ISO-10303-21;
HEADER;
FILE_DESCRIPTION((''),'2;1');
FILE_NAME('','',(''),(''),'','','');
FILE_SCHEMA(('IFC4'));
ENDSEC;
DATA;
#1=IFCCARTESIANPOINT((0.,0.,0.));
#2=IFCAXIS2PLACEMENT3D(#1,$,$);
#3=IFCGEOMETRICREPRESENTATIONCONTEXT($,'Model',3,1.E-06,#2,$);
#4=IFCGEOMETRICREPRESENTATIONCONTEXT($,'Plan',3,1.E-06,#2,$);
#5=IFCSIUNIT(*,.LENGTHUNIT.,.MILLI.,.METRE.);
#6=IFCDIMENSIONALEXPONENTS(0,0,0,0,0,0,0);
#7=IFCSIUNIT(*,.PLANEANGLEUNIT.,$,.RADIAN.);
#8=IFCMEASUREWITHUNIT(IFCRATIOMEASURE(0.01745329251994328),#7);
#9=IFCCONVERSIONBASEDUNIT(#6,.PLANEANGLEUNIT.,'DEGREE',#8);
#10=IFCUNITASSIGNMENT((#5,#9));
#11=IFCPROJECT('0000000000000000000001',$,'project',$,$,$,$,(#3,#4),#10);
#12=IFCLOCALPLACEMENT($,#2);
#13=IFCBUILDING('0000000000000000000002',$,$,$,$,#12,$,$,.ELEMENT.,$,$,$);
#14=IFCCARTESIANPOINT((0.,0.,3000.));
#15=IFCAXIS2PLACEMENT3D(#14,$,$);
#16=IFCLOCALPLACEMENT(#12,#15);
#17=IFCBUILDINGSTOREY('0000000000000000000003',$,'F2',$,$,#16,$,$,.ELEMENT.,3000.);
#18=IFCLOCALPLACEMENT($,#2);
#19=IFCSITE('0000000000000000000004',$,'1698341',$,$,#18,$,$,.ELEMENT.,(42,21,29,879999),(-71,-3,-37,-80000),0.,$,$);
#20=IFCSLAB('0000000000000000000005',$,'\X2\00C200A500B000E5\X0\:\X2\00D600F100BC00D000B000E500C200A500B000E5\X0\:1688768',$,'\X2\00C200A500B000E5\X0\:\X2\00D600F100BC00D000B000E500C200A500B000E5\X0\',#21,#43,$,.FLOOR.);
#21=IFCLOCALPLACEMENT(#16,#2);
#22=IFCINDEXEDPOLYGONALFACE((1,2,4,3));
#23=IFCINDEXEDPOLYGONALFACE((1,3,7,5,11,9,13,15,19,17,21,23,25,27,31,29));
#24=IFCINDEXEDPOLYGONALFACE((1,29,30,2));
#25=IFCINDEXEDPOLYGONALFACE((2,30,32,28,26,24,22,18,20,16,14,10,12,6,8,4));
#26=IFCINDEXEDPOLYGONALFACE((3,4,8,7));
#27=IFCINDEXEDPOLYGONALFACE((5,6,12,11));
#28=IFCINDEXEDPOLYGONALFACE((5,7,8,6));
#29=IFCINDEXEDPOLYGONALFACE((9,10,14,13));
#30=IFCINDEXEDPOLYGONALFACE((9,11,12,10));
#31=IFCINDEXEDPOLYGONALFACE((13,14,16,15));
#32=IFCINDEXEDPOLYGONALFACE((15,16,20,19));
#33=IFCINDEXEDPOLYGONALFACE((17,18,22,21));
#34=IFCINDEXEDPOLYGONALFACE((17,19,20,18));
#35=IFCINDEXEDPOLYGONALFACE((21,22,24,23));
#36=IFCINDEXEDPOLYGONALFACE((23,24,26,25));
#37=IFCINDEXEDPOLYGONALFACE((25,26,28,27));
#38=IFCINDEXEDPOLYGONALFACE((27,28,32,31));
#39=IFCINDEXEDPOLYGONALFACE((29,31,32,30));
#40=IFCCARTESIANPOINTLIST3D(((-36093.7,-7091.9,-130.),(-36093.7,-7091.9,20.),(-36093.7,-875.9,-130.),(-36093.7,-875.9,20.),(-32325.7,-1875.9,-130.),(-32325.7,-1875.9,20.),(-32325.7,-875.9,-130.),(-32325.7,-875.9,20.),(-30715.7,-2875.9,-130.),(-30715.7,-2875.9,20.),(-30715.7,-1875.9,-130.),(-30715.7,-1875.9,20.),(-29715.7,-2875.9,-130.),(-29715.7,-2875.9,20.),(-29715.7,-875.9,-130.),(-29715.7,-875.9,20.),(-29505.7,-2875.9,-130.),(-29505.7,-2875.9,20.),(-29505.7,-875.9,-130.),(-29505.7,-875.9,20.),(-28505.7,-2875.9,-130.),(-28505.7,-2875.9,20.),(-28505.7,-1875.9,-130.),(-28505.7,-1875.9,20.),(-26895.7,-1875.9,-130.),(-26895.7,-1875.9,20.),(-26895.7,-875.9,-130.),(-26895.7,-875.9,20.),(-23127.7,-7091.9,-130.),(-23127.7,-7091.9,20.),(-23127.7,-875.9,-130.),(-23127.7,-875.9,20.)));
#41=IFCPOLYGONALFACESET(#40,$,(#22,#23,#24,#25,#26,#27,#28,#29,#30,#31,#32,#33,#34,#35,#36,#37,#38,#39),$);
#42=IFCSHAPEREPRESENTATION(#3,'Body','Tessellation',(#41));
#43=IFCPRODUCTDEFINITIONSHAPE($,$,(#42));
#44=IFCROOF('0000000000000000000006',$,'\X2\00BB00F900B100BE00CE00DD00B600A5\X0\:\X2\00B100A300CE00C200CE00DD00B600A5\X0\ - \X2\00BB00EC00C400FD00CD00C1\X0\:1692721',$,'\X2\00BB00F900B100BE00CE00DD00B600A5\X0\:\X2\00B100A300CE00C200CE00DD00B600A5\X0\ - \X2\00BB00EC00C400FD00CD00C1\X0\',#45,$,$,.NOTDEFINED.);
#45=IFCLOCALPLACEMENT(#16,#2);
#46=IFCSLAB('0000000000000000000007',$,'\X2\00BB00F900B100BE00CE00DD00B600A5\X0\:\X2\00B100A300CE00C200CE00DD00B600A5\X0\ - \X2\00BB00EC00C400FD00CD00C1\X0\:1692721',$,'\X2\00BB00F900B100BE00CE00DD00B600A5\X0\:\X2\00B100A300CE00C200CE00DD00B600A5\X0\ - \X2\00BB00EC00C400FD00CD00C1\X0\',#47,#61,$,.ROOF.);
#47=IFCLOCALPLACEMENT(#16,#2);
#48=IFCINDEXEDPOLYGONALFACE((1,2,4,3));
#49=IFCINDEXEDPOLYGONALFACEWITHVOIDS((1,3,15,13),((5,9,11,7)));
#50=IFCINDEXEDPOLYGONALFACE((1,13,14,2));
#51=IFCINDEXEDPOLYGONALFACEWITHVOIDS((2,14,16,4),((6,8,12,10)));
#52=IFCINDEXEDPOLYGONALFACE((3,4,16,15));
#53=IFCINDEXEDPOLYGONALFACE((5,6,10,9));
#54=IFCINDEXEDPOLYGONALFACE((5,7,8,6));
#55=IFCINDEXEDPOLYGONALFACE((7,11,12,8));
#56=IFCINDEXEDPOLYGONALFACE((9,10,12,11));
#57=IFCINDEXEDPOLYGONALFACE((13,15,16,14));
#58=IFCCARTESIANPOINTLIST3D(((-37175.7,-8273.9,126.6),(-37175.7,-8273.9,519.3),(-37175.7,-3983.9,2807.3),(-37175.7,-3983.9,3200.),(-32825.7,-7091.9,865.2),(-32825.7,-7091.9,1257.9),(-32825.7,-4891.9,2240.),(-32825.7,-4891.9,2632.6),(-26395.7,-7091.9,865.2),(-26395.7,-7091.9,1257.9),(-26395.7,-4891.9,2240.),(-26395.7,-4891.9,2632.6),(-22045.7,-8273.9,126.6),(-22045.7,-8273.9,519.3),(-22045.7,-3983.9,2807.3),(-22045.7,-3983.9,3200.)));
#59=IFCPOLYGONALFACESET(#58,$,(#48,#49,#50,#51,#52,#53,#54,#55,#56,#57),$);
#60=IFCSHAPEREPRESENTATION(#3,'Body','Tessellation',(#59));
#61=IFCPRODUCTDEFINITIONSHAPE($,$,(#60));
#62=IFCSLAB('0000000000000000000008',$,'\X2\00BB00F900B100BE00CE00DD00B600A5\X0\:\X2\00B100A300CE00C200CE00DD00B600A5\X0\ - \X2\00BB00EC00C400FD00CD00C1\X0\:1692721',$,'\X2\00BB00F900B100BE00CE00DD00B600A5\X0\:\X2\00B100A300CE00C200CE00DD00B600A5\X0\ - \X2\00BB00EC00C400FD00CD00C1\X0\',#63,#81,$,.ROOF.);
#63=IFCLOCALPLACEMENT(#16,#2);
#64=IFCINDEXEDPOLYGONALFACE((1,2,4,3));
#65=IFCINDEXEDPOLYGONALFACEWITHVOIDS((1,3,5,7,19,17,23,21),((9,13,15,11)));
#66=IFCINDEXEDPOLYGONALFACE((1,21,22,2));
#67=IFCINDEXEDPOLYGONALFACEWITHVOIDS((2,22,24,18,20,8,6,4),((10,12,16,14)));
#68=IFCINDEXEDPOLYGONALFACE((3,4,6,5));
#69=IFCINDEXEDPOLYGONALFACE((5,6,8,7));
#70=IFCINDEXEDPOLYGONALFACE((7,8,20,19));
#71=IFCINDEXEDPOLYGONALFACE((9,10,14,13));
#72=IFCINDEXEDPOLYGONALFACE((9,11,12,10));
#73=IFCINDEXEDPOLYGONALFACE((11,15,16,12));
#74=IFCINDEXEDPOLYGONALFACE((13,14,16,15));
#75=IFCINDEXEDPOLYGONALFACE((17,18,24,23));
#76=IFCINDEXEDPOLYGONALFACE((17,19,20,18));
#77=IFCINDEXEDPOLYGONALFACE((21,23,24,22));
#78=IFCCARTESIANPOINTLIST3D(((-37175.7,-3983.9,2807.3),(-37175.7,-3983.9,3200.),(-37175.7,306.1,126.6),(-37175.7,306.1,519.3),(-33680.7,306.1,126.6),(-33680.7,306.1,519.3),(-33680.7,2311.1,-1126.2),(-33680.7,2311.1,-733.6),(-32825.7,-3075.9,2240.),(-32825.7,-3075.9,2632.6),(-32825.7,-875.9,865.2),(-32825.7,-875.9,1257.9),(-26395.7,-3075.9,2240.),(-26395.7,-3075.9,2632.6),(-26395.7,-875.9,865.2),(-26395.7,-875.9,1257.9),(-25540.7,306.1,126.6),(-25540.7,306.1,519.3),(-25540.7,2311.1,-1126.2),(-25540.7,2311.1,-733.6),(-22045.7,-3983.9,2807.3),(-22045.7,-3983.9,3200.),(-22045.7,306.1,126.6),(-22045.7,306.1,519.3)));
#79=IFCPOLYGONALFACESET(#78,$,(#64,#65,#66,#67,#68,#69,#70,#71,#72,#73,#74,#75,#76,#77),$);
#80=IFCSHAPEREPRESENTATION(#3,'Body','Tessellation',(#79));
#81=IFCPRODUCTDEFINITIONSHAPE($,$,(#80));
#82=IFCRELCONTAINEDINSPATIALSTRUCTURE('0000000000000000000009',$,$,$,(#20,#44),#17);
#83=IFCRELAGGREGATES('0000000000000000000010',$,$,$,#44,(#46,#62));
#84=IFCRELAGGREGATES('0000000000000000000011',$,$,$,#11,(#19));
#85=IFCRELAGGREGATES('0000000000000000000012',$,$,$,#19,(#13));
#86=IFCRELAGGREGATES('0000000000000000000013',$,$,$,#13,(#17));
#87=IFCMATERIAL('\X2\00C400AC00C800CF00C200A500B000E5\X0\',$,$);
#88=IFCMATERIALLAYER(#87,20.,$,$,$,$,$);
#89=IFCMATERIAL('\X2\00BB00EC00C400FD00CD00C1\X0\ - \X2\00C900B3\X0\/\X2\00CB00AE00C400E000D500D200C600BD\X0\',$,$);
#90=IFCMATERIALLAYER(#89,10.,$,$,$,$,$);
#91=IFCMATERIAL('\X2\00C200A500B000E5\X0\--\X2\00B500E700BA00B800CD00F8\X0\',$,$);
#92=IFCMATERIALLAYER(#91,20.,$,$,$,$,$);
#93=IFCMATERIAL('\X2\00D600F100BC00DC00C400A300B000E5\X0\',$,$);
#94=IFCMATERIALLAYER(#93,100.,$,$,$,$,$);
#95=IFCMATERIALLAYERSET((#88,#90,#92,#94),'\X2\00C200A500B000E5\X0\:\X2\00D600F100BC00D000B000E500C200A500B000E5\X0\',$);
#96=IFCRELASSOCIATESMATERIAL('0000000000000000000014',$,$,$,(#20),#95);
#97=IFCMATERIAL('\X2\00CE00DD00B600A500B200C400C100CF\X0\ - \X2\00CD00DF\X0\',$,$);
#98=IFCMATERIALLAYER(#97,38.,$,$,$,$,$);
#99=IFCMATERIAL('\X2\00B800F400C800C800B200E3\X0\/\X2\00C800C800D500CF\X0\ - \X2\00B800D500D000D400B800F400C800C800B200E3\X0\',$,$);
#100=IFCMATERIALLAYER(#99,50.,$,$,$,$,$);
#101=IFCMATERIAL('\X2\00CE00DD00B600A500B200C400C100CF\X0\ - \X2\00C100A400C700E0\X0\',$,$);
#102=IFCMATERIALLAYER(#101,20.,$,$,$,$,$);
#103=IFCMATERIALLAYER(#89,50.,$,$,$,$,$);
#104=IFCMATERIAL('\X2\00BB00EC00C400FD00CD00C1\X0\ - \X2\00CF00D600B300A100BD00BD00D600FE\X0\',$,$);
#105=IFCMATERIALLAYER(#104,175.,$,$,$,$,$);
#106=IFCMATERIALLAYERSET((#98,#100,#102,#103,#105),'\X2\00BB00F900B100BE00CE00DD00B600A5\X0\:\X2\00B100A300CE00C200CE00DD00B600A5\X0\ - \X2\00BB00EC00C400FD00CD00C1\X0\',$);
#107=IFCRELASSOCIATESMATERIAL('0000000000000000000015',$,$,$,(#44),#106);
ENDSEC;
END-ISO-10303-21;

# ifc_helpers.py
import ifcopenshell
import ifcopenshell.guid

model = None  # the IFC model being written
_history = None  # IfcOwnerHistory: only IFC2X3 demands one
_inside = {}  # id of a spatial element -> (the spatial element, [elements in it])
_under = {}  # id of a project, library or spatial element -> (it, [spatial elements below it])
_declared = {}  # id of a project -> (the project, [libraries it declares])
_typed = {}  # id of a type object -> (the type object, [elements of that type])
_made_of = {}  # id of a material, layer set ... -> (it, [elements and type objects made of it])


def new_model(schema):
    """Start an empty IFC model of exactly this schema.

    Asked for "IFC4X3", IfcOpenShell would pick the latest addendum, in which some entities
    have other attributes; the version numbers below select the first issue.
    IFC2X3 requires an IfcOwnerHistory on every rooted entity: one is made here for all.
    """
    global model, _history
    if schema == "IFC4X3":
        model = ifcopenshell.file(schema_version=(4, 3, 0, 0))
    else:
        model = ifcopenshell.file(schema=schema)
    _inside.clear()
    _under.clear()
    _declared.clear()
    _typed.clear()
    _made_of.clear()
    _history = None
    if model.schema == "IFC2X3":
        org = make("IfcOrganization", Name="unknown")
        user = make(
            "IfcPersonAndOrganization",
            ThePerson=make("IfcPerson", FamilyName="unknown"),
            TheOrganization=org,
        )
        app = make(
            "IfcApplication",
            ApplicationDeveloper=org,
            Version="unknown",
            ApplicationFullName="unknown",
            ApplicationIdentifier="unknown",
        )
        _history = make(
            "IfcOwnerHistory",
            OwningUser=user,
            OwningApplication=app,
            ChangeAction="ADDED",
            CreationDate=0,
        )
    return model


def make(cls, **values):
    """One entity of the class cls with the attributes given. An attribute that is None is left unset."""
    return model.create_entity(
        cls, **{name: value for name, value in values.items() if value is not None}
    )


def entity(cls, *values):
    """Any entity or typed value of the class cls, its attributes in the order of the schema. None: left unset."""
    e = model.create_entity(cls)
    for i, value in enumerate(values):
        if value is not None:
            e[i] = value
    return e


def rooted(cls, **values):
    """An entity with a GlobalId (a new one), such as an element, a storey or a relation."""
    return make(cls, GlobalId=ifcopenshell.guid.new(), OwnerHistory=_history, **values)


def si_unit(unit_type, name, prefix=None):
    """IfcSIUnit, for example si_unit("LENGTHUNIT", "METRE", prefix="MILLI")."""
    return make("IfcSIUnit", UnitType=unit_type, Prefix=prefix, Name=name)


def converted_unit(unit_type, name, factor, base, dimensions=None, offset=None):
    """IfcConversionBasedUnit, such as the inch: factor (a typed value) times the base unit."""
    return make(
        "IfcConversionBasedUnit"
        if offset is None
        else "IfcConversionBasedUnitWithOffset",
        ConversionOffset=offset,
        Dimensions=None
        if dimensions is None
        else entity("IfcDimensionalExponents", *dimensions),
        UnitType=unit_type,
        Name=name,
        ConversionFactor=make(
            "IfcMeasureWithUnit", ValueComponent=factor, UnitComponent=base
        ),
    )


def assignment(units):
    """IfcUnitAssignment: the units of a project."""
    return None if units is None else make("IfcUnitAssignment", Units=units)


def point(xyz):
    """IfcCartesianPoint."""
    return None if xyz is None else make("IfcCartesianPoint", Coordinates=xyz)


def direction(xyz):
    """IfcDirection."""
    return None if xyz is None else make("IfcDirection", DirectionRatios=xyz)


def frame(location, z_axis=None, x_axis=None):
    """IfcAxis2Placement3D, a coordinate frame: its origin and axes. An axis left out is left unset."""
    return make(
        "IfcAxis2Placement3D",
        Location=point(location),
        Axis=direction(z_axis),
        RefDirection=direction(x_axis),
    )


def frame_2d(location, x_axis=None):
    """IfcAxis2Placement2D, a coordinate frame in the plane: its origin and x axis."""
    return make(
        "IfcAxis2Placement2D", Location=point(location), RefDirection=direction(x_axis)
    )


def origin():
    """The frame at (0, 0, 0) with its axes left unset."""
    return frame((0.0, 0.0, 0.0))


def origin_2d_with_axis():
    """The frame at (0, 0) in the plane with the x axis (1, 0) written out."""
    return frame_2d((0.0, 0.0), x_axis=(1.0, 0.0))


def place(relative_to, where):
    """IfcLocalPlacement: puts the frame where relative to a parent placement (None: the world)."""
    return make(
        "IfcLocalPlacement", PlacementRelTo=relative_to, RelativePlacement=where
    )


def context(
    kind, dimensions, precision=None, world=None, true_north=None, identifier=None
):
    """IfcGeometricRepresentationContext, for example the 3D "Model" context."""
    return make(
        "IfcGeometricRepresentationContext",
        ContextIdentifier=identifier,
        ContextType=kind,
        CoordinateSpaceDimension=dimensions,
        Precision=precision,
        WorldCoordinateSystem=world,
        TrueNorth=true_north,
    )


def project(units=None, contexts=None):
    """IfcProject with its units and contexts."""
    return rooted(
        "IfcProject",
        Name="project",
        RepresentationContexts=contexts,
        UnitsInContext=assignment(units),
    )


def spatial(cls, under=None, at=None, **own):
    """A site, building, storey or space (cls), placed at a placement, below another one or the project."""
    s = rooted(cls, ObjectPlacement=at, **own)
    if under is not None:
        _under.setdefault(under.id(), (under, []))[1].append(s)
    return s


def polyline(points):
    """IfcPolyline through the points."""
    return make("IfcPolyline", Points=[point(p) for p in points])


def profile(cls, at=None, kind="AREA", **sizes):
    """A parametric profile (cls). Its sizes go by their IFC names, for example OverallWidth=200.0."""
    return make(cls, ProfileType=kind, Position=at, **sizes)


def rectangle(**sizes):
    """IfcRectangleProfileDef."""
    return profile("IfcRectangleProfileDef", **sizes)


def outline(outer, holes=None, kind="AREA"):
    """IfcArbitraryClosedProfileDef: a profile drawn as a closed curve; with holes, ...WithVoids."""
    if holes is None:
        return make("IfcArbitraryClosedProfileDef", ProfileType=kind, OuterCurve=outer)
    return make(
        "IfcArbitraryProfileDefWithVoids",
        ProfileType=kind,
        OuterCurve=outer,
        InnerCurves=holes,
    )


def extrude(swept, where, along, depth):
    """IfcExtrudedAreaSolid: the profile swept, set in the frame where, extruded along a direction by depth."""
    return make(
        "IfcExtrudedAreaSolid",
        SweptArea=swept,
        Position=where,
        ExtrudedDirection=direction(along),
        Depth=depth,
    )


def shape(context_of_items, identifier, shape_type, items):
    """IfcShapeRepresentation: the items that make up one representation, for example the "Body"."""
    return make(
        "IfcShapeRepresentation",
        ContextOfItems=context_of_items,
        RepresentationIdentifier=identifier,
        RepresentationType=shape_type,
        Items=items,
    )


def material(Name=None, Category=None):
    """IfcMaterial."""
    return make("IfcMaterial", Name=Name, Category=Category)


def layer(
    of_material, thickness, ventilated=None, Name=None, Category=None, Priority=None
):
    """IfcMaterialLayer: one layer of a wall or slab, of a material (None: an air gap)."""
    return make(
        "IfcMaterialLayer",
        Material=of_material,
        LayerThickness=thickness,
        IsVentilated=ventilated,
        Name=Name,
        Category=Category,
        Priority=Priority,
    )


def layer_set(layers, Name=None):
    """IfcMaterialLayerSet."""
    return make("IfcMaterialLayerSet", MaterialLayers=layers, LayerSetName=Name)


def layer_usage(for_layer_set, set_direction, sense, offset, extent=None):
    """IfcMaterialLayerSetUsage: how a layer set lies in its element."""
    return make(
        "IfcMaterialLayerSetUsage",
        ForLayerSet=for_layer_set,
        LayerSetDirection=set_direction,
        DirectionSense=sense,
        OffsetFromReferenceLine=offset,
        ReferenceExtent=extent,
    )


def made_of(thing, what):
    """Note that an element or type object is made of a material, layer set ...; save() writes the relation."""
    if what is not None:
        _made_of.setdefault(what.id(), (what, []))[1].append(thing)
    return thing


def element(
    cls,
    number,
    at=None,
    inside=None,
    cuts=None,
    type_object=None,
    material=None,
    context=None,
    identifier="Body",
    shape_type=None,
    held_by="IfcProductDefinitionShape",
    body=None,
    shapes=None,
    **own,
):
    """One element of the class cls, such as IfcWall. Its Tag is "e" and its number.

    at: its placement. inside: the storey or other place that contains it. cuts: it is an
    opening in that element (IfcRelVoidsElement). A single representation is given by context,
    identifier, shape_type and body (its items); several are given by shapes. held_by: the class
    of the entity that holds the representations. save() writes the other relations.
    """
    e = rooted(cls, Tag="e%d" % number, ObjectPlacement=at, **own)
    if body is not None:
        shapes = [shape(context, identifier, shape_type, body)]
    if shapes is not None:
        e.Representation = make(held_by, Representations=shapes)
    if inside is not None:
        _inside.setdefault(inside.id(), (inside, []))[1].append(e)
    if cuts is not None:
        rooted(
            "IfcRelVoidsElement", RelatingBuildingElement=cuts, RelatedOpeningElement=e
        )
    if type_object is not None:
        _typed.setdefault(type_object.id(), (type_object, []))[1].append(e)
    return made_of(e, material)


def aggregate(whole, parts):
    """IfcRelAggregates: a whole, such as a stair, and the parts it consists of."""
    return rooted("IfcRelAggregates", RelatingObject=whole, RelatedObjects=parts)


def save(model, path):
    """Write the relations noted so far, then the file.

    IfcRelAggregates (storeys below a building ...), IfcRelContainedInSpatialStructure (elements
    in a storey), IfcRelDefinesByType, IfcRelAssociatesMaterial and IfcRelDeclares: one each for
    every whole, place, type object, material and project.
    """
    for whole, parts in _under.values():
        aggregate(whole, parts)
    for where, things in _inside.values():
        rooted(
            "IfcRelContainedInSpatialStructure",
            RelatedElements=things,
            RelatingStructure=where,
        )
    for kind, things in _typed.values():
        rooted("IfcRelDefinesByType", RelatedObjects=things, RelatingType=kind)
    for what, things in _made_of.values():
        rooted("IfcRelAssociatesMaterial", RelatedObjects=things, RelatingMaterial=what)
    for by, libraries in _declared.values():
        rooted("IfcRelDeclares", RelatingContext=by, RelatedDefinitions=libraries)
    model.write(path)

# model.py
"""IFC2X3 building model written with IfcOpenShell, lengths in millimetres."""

from ifc_helpers import new_model, entity, si_unit, converted_unit, frame, frame_2d, origin, origin_2d_with_axis, place, context, project, spatial, polyline, rectangle, outline, extrude, material, layer, layer_set, layer_usage, element, aggregate, save


model = new_model("IFC2X3")

# Units and contexts
model_context = context("Model", 3, precision=1e-06, world=origin())
plan_context = context("Plan", 3, precision=1e-06, world=origin())
ifc_project = project(units=[si_unit("LENGTHUNIT", "METRE", prefix="MILLI"), converted_unit("PLANEANGLEUNIT", "DEGREE", entity("IfcRatioMeasure", 0.01745329251994328), si_unit("PLANEANGLEUNIT", "RADIAN"), dimensions=[0, 0, 0, 0, 0, 0, 0])], contexts=[model_context, plan_context])

# Site, building, storey
site_placement = place(None, origin())
site = spatial("IfcSite", under=ifc_project, at=site_placement, Name="1698341", CompositionType="ELEMENT", RefLatitude=(42, 21, 29, 879999), RefLongitude=(-71, -3, -37, -80000), RefElevation=0.0)
building_placement = place(None, origin())
building = spatial("IfcBuilding", under=site, at=building_placement, CompositionType="ELEMENT")
storey_placement = place(building_placement, frame((0.0, 0.0, 3000.0)))
storey = spatial("IfcBuildingStorey", under=building, at=storey_placement, Name="F2", CompositionType="ELEMENT", Elevation=3000.0)

# Slab, openings
ifc_material_1 = material(Name="Ä¬ÈÏÂ¥°å")
ifc_layer_1 = layer(ifc_material_1, 20.0)
ifc_material_2 = material(Name="»ìÄýÍÁ - É³/Ë®ÄàÕÒÆ½")
ifc_layer_2 = layer(ifc_material_2, 10.0)
ifc_material_3 = material(Name="Â¥°å--µçº¸Íø")
ifc_layer_3 = layer(ifc_material_3, 20.0)
ifc_material_4 = material(Name="Öñ¼ÜÄ£°å")
ifc_layer_4 = layer(ifc_material_4, 100.0)
ifc_layer_set_1 = layer_set([ifc_layer_1, ifc_layer_2, ifc_layer_3, ifc_layer_4], Name="Â¥°å:Öñ¼Ð°åÂ¥°å")
ifc_layer_usage_1 = layer_usage(ifc_layer_set_1, "AXIS3", "POSITIVE", 0.0)
slab_1_placement = place(storey_placement, frame((-36093.7, -7091.9, -130.0)))
slab_1 = element("IfcSlab", 1, at=slab_1_placement, inside=storey, material=ifc_layer_usage_1, Name="Â¥°å:Öñ¼Ð°åÂ¥°å:1688768", ObjectType="Â¥°å:Öñ¼Ð°åÂ¥°å", PredefinedType="FLOOR", context=model_context, shape_type="SweptSolid", body=[
    extrude(rectangle(XDim=6216.0, YDim=12966.0, at=frame_2d((0.0, 0.0), x_axis=(0.0, -1.0))), frame((6483.0, 3108.0, 150.0), z_axis=(0.0, 0.0, -1.0), x_axis=(-1.0, 0.0, 0.0)), (0.0, 0.0, 1.0), 150.0),
])
opening_1_placement = place(storey_placement, frame((-36093.7, -7091.9, -130.0)))
element("IfcOpeningElement", 2, at=opening_1_placement, cuts=slab_1, ObjectType="Opening", context=model_context, shape_type="SweptSolid", body=[
    extrude(outline(polyline([(2715.0, 3108.0), (105.0, 3108.0), (105.0, 1108.0), (1105.0, 1108.0), (1105.0, 2108.0), (2715.0, 2108.0), (2715.0, 3108.0)])), frame((6483.0, 3108.0, 150.0), z_axis=(0.0, 0.0, -1.0), x_axis=(-1.0, 0.0, 0.0)), (0.0, 0.0, 1.0), 150.0),
])
opening_2_placement = place(storey_placement, frame((-36093.7, -7091.9, -130.0)))
element("IfcOpeningElement", 3, at=opening_2_placement, cuts=slab_1, ObjectType="Opening", context=model_context, shape_type="SweptSolid", body=[
    extrude(outline(polyline([(-2715.0, 3108.0), (-2715.0, 2108.0), (-1105.0, 2108.0), (-1105.0, 1108.0), (-105.0, 1108.0), (-105.0, 3108.0), (-2715.0, 3108.0)])), frame((6483.0, 3108.0, 150.0), z_axis=(0.0, 0.0, -1.0), x_axis=(-1.0, 0.0, 0.0)), (0.0, 0.0, 1.0), 150.0),
])

# Roof, slabs, openings
ifc_material_5 = material(Name="ÎÝ¶¥²ÄÁÏ - Íß")
ifc_layer_5 = layer(ifc_material_5, 38.0)
ifc_material_6 = material(Name="¸ôÈÈ²ã/ÈÈÕÏ - ¸ÕÐÔ¸ôÈÈ²ã")
ifc_layer_6 = layer(ifc_material_6, 50.0)
ifc_material_7 = material(Name="ÎÝ¶¥²ÄÁÏ - Á¤Çà")
ifc_layer_7 = layer(ifc_material_7, 20.0)
ifc_layer_8 = layer(ifc_material_2, 50.0)
ifc_material_8 = material(Name="»ìÄýÍÁ - ÏÖ³¡½½Öþ")
ifc_layer_9 = layer(ifc_material_8, 175.0)
ifc_layer_set_2 = layer_set([ifc_layer_5, ifc_layer_6, ifc_layer_7, ifc_layer_8, ifc_layer_9], Name="»ù±¾ÎÝ¶¥:±£ÎÂÎÝ¶¥ - »ìÄýÍÁ")
ifc_layer_usage_2 = layer_usage(ifc_layer_set_2, "AXIS3", "NEGATIVE", 0.0)
roof_placement = place(storey_placement, origin())
roof = element("IfcRoof", 4, at=roof_placement, inside=storey, material=ifc_layer_usage_2, Name="»ù±¾ÎÝ¶¥:±£ÎÂÎÝ¶¥ - »ìÄýÍÁ:1692721", ObjectType="»ù±¾ÎÝ¶¥:±£ÎÂÎÝ¶¥ - »ìÄýÍÁ", ShapeType="NOTDEFINED")
slab_2_placement = place(roof_placement, frame((-37175.7, -8273.9, -1126.2)))
slab_2 = element("IfcSlab", 5, at=slab_2_placement, Name="»ù±¾ÎÝ¶¥:±£ÎÂÎÝ¶¥ - »ìÄýÍÁ:1692721", ObjectType="»ù±¾ÎÝ¶¥:±£ÎÂÎÝ¶¥ - »ìÄýÍÁ", PredefinedType="ROOF", context=model_context, shape_type="SweptSolid", body=[
    extrude(rectangle(XDim=5058.7, YDim=15130.0, at=frame_2d((0.0, 0.0), x_axis=(0.0, -1.0))), frame((7565.0, 2145.0, 2593.2), z_axis=(0.0, -0.529919, 0.848048), x_axis=(1.0, 0.0, 0.0)), (0.0, 0.529919, 0.848048), 392.7),
])
opening_3_placement = place(roof_placement, frame((-37175.7, -8273.9, -1126.2)))
element("IfcOpeningElement", 6, at=opening_3_placement, cuts=slab_2, ObjectType="Opening", context=model_context, shape_type="SweptSolid", body=[
    extrude(rectangle(XDim=2594.2, YDim=6430.0, at=frame_2d((0.0, 0.0), x_axis=(0.0, 1.0))), frame((7565.0, 2282.0, 2678.8), z_axis=(0.0, -0.529919, 0.848048), x_axis=(-1.0, 0.0, 0.0)), (0.0, -0.529919, 0.848048), 392.7),
])
slab_3_placement = place(roof_placement, frame((-37175.7, -8273.9, -1126.2)))
slab_3 = element("IfcSlab", 7, at=slab_3_placement, Name="»ù±¾ÎÝ¶¥:±£ÎÂÎÝ¶¥ - »ìÄýÍÁ:1692721", ObjectType="»ù±¾ÎÝ¶¥:±£ÎÂÎÝ¶¥ - »ìÄýÍÁ", PredefinedType="ROOF", context=model_context, shape_type="SweptSolid", body=[
    extrude(outline(polyline([(-7565.0, -3711.5), (7565.0, -3711.5), (7565.0, 1347.2), (4070.0, 1347.2), (4070.0, 3711.5), (-4070.0, 3711.5), (-4070.0, 1347.2), (-7565.0, 1347.2), (-7565.0, -3711.5)])), frame((7565.0, 7437.5, 1966.8), z_axis=(0.0, 0.529919, 0.848048), x_axis=(1.0, 0.0, 0.0)), (0.0, -0.529919, 0.848048), 392.7),
])
opening_4_placement = place(roof_placement, frame((-37175.7, -8273.9, -1126.2)))
element("IfcOpeningElement", 8, at=opening_4_placement, cuts=slab_3, ObjectType="Opening", context=model_context, shape_type="SweptSolid", body=[
    extrude(rectangle(XDim=2594.2, YDim=6430.0, at=origin_2d_with_axis()), frame((7565.0, 6298.0, 2678.8), z_axis=(0.0, 0.529919, 0.848048), x_axis=(0.0, 0.848048, -0.529919)), (-0.529919, 0.0, 0.848048), 392.7),
])
aggregate(roof, [slab_2, slab_3])

save(model, "model.ifc")
